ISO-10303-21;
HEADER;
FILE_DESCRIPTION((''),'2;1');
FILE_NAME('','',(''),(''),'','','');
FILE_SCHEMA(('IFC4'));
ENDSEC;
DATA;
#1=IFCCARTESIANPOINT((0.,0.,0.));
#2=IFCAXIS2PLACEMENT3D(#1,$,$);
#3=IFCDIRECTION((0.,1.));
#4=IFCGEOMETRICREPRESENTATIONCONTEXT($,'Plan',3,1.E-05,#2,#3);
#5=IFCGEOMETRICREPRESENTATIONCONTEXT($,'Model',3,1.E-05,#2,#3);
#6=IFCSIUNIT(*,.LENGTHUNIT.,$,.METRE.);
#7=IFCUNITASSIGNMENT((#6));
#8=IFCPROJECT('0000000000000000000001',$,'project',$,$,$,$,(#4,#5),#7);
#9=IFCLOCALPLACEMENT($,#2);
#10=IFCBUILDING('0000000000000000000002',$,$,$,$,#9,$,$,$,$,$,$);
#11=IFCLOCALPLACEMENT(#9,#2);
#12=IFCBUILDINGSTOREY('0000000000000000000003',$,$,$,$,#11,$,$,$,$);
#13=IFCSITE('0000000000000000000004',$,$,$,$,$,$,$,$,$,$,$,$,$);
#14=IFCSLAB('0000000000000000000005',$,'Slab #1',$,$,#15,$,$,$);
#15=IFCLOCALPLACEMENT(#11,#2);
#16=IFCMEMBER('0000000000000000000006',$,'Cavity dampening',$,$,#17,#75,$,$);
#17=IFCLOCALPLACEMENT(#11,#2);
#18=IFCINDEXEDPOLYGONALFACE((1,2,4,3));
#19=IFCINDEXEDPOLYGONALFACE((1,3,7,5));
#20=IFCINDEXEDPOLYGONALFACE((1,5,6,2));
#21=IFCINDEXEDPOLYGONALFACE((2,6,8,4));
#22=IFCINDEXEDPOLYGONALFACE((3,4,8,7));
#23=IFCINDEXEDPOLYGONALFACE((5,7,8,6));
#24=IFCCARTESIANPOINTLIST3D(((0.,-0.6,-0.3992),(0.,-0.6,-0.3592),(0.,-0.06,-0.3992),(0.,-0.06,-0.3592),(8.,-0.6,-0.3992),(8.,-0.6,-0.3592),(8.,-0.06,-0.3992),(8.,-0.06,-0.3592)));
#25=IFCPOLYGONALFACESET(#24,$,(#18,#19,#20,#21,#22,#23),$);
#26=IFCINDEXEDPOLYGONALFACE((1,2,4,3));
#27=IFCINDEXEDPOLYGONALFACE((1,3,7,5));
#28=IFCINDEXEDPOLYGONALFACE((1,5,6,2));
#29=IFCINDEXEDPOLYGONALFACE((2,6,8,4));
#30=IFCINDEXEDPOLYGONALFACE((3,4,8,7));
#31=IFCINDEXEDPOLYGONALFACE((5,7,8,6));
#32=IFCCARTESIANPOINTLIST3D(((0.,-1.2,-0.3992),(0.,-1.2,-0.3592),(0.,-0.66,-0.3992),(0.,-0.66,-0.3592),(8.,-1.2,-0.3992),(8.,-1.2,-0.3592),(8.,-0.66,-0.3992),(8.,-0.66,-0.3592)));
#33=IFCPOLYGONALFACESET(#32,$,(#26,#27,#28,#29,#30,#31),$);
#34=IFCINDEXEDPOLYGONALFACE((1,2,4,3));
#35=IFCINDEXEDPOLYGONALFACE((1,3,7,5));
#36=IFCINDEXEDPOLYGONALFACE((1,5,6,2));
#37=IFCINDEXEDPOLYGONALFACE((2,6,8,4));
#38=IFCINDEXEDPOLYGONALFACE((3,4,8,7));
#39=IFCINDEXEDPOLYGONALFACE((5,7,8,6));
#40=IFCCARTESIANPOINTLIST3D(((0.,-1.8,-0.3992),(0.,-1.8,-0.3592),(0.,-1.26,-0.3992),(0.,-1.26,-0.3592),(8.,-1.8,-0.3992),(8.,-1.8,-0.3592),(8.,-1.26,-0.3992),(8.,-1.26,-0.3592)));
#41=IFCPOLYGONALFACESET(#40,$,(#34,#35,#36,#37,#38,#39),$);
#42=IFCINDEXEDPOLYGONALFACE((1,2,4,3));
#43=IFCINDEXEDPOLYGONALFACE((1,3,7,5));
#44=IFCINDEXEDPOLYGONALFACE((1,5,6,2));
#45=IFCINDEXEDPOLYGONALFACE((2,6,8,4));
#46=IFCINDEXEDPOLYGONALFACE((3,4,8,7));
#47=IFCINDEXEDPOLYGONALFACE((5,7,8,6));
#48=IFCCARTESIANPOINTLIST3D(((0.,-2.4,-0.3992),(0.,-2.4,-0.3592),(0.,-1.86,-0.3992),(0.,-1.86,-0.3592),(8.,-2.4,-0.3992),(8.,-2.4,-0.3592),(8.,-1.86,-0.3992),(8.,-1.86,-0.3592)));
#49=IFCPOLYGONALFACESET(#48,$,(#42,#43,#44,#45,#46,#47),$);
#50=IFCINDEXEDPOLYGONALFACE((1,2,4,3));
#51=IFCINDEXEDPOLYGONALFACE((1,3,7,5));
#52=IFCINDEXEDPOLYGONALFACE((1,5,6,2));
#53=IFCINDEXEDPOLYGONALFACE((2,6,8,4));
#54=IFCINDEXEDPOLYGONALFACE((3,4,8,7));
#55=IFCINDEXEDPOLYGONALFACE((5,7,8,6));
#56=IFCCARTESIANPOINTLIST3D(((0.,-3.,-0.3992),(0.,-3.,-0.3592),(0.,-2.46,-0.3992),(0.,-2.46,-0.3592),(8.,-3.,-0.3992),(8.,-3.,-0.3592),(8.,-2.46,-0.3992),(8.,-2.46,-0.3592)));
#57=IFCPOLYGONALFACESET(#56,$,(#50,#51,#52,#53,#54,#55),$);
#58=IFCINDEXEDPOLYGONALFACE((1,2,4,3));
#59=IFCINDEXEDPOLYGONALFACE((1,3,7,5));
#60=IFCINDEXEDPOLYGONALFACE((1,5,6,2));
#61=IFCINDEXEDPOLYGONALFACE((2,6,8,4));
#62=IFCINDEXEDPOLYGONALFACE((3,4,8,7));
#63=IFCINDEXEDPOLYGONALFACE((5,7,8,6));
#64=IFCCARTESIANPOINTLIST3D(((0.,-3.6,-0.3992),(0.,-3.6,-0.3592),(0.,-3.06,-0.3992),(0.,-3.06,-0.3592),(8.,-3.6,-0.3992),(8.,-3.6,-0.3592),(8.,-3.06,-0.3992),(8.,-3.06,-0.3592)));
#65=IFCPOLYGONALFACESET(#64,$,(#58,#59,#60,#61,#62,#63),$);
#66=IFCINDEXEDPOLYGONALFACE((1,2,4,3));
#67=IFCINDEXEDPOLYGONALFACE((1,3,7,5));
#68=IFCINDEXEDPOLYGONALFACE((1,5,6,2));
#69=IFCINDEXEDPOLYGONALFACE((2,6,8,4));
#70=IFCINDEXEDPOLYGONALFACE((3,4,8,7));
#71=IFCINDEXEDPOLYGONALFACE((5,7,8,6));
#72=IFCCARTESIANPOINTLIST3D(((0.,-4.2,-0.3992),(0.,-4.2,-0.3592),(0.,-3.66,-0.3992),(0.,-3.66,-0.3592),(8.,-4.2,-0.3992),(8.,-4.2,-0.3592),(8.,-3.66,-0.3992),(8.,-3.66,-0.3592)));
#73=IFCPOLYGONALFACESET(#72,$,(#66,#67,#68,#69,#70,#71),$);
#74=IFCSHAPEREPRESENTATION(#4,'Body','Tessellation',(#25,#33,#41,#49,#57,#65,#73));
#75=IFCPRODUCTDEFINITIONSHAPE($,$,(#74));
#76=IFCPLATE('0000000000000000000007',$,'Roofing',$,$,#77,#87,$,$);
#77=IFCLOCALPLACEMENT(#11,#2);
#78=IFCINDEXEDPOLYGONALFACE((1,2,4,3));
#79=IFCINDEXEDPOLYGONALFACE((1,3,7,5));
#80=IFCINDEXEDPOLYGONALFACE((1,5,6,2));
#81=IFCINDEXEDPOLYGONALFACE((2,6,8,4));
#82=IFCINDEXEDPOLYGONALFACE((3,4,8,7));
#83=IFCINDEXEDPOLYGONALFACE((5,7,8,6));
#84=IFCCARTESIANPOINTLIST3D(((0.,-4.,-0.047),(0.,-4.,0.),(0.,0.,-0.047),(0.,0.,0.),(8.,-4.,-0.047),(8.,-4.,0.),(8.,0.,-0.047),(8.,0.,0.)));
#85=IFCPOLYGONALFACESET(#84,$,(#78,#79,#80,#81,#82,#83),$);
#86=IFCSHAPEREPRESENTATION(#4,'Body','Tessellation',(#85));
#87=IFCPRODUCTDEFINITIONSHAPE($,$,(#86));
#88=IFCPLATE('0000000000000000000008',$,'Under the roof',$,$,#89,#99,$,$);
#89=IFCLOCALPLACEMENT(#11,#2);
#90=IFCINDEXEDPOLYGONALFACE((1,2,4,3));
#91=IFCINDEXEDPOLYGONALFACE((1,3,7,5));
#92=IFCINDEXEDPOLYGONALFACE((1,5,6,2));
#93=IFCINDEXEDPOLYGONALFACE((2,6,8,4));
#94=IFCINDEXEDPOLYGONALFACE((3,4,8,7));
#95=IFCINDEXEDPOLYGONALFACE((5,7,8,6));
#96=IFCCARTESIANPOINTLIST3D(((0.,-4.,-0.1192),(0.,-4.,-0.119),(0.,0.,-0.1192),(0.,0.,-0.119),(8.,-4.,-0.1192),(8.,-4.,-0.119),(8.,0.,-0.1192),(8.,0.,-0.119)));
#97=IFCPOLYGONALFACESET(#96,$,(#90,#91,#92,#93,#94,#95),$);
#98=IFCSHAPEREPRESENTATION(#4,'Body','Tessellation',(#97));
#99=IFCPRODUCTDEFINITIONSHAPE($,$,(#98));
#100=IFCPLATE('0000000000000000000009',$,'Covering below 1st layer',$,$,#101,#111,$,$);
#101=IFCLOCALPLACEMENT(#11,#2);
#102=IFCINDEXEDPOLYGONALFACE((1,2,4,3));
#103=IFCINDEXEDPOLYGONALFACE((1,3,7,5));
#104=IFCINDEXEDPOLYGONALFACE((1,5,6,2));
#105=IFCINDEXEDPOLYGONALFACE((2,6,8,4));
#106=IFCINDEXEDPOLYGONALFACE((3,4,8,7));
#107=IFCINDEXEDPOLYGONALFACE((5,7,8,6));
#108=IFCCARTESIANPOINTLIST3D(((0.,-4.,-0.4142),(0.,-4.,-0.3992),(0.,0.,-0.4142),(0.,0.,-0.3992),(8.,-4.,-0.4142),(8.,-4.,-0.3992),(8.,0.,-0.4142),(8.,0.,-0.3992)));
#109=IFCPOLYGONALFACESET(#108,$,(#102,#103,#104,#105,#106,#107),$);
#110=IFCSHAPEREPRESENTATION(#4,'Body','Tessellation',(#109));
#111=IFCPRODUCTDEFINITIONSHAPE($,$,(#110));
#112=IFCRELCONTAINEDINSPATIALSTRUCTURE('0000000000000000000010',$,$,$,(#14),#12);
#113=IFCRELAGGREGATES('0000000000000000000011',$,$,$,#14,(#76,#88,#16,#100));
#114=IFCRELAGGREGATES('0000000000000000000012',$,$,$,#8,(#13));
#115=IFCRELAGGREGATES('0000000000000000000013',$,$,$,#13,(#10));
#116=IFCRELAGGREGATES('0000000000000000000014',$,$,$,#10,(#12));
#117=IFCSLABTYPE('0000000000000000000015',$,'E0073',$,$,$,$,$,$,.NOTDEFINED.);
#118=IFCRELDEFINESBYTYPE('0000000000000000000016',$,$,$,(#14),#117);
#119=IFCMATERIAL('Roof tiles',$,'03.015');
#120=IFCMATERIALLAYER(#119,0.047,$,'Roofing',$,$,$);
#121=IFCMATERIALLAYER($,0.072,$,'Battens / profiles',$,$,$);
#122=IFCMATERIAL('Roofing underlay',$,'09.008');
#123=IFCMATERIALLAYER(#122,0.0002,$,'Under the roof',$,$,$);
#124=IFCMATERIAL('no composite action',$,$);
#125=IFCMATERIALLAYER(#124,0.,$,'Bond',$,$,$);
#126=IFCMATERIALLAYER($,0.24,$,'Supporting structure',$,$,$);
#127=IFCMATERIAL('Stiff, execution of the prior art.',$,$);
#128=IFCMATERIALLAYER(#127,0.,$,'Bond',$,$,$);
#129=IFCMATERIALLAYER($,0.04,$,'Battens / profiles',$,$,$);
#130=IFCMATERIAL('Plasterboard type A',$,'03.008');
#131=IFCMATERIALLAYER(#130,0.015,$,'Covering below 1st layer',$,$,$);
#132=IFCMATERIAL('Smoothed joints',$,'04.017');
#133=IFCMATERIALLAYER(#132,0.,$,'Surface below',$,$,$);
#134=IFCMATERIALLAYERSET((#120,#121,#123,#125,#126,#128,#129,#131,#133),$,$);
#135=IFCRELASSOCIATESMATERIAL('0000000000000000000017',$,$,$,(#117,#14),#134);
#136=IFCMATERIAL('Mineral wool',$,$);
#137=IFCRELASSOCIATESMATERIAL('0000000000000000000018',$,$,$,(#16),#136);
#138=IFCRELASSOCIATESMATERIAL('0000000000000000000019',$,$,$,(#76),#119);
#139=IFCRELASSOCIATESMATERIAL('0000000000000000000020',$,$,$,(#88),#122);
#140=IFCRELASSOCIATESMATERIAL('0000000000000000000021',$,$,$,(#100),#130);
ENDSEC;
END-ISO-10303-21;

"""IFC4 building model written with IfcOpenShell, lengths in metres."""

from ifc_helpers import new_model, si_unit, direction, frame, frame_2d, origin, origin_with_axes, place, context, project, spatial, rectangle, extrude, material, layer, layer_set, type_object, element, aggregate, save


model = new_model("IFC4")

# Units and contexts
plan_context = context("Plan", 3, precision=1e-05, world=origin(), true_north=direction((0.0, 1.0)))
model_context = context("Model", 3, precision=1e-05, world=origin(), true_north=direction((0.0, 1.0)))
ifc_project = project(units=[si_unit("LENGTHUNIT", "METRE")], contexts=[plan_context, model_context])

# Site, building, storey
site = spatial("IfcSite", under=ifc_project)
building_placement = place(None, origin())
building = spatial("IfcBuilding", under=site, at=building_placement)
storey_placement = place(building_placement, origin())
storey = spatial("IfcBuildingStorey", under=building, at=storey_placement)

# Slab, member, plates
ifc_material_1 = material(Name="Roof tiles", Category="03.015")
ifc_layer_1 = layer(ifc_material_1, 0.047, Name="Roofing")
ifc_layer_2 = layer(None, 0.072, Name="Battens / profiles")
ifc_material_2 = material(Name="Roofing underlay", Category="09.008")
ifc_layer_3 = layer(ifc_material_2, 0.0002, Name="Under the roof")
ifc_material_3 = material(Name="no composite action")
ifc_layer_4 = layer(ifc_material_3, 0.0, Name="Bond")
ifc_layer_5 = layer(None, 0.24, Name="Supporting structure")
ifc_material_4 = material(Name="Stiff, execution of the prior art.")
ifc_layer_6 = layer(ifc_material_4, 0.0, Name="Bond")
ifc_layer_7 = layer(None, 0.04, Name="Battens / profiles")
ifc_material_5 = material(Name="Plasterboard type A", Category="03.008")
ifc_layer_8 = layer(ifc_material_5, 0.015, Name="Covering below 1st layer")
ifc_material_6 = material(Name="Smoothed joints", Category="04.017")
ifc_layer_9 = layer(ifc_material_6, 0.0, Name="Surface below")
ifc_layer_set = layer_set([ifc_layer_1, ifc_layer_2, ifc_layer_3, ifc_layer_4, ifc_layer_5, ifc_layer_6, ifc_layer_7, ifc_layer_8, ifc_layer_9])
slab_type = type_object("IfcSlabType", Name="E0073", PredefinedType="NOTDEFINED", material=ifc_layer_set)
slab_placement = place(None, frame((0.0, 0.0, 0.0), z_axis=(0.0, 0.0, -1.0), x_axis=(1.0, 0.0, 0.0)))
slab = element("IfcSlab", 1, at=slab_placement, inside=storey, type_object=slab_type, material=ifc_layer_set, Name="Slab #1")
ifc_material_7 = material(Name="Mineral wool")
member_1_placement = place(slab_placement, origin())
member_1 = element("IfcMember", 2, at=member_1_placement, material=ifc_material_7, Name="Cavity dampening", context=plan_context, shape_type="SweptSolid", body=[
    extrude(rectangle(XDim=0.54, YDim=0.04, at=frame_2d((0.27, 0.02), x_axis=(1.0, 0.0))), frame((0.0, 0.06, 0.3592), z_axis=(1.0, 0.0, 0.0), x_axis=(0.0, 1.0, 0.0)), (0.0, 0.0, 1.0), 8.0),
    extrude(rectangle(XDim=0.54, YDim=0.04, at=frame_2d((0.27, 0.02), x_axis=(1.0, 0.0))), frame((0.0, 0.66, 0.3592), z_axis=(1.0, 0.0, 0.0), x_axis=(0.0, 1.0, 0.0)), (0.0, 0.0, 1.0), 8.0),
    extrude(rectangle(XDim=0.54, YDim=0.04, at=frame_2d((0.27, 0.02), x_axis=(1.0, 0.0))), frame((0.0, 1.26, 0.3592), z_axis=(1.0, 0.0, 0.0), x_axis=(0.0, 1.0, 0.0)), (0.0, 0.0, 1.0), 8.0),
    extrude(rectangle(XDim=0.54, YDim=0.04, at=frame_2d((0.27, 0.02), x_axis=(1.0, 0.0))), frame((0.0, 1.86, 0.3592), z_axis=(1.0, 0.0, 0.0), x_axis=(0.0, 1.0, 0.0)), (0.0, 0.0, 1.0), 8.0),
    extrude(rectangle(XDim=0.54, YDim=0.04, at=frame_2d((0.27, 0.02), x_axis=(1.0, 0.0))), frame((0.0, 2.46, 0.3592), z_axis=(1.0, 0.0, 0.0), x_axis=(0.0, 1.0, 0.0)), (0.0, 0.0, 1.0), 8.0),
    extrude(rectangle(XDim=0.54, YDim=0.04, at=frame_2d((0.27, 0.02), x_axis=(1.0, 0.0))), frame((0.0, 3.06, 0.3592), z_axis=(1.0, 0.0, 0.0), x_axis=(0.0, 1.0, 0.0)), (0.0, 0.0, 1.0), 8.0),
    extrude(rectangle(XDim=0.54, YDim=0.04, at=frame_2d((0.27, 0.02), x_axis=(1.0, 0.0))), frame((0.0, 3.66, 0.3592), z_axis=(1.0, 0.0, 0.0), x_axis=(0.0, 1.0, 0.0)), (0.0, 0.0, 1.0), 8.0),
])
plate_1_placement = place(slab_placement, origin())
plate_1 = element("IfcPlate", 3, at=plate_1_placement, material=ifc_material_1, Name="Roofing", context=plan_context, shape_type="SweptSolid", body=[
    extrude(rectangle(XDim=8.0, YDim=4.0, at=frame_2d((4.0, 2.0), x_axis=(1.0, 0.0))), origin_with_axes(), (0.0, 0.0, 1.0), 0.047),
])
plate_2_placement = place(slab_placement, origin())
plate_2 = element("IfcPlate", 4, at=plate_2_placement, material=ifc_material_2, Name="Under the roof", context=plan_context, shape_type="SweptSolid", body=[
    extrude(rectangle(XDim=8.0, YDim=4.0, at=frame_2d((4.0, 2.0), x_axis=(1.0, 0.0))), frame((0.0, 0.0, 0.119), z_axis=(0.0, 0.0, 1.0), x_axis=(1.0, 0.0, 0.0)), (0.0, 0.0, 1.0), 0.0002),
])
plate_3_placement = place(slab_placement, origin())
plate_3 = element("IfcPlate", 5, at=plate_3_placement, material=ifc_material_5, Name="Covering below 1st layer", context=plan_context, shape_type="SweptSolid", body=[
    extrude(rectangle(XDim=8.0, YDim=4.0, at=frame_2d((4.0, 2.0), x_axis=(1.0, 0.0))), frame((0.0, 0.0, 0.3992), z_axis=(0.0, 0.0, 1.0), x_axis=(1.0, 0.0, 0.0)), (0.0, 0.0, 1.0), 0.015),
])
aggregate(slab, [plate_1, plate_2, member_1, plate_3])

save(model, "model.ifc")
